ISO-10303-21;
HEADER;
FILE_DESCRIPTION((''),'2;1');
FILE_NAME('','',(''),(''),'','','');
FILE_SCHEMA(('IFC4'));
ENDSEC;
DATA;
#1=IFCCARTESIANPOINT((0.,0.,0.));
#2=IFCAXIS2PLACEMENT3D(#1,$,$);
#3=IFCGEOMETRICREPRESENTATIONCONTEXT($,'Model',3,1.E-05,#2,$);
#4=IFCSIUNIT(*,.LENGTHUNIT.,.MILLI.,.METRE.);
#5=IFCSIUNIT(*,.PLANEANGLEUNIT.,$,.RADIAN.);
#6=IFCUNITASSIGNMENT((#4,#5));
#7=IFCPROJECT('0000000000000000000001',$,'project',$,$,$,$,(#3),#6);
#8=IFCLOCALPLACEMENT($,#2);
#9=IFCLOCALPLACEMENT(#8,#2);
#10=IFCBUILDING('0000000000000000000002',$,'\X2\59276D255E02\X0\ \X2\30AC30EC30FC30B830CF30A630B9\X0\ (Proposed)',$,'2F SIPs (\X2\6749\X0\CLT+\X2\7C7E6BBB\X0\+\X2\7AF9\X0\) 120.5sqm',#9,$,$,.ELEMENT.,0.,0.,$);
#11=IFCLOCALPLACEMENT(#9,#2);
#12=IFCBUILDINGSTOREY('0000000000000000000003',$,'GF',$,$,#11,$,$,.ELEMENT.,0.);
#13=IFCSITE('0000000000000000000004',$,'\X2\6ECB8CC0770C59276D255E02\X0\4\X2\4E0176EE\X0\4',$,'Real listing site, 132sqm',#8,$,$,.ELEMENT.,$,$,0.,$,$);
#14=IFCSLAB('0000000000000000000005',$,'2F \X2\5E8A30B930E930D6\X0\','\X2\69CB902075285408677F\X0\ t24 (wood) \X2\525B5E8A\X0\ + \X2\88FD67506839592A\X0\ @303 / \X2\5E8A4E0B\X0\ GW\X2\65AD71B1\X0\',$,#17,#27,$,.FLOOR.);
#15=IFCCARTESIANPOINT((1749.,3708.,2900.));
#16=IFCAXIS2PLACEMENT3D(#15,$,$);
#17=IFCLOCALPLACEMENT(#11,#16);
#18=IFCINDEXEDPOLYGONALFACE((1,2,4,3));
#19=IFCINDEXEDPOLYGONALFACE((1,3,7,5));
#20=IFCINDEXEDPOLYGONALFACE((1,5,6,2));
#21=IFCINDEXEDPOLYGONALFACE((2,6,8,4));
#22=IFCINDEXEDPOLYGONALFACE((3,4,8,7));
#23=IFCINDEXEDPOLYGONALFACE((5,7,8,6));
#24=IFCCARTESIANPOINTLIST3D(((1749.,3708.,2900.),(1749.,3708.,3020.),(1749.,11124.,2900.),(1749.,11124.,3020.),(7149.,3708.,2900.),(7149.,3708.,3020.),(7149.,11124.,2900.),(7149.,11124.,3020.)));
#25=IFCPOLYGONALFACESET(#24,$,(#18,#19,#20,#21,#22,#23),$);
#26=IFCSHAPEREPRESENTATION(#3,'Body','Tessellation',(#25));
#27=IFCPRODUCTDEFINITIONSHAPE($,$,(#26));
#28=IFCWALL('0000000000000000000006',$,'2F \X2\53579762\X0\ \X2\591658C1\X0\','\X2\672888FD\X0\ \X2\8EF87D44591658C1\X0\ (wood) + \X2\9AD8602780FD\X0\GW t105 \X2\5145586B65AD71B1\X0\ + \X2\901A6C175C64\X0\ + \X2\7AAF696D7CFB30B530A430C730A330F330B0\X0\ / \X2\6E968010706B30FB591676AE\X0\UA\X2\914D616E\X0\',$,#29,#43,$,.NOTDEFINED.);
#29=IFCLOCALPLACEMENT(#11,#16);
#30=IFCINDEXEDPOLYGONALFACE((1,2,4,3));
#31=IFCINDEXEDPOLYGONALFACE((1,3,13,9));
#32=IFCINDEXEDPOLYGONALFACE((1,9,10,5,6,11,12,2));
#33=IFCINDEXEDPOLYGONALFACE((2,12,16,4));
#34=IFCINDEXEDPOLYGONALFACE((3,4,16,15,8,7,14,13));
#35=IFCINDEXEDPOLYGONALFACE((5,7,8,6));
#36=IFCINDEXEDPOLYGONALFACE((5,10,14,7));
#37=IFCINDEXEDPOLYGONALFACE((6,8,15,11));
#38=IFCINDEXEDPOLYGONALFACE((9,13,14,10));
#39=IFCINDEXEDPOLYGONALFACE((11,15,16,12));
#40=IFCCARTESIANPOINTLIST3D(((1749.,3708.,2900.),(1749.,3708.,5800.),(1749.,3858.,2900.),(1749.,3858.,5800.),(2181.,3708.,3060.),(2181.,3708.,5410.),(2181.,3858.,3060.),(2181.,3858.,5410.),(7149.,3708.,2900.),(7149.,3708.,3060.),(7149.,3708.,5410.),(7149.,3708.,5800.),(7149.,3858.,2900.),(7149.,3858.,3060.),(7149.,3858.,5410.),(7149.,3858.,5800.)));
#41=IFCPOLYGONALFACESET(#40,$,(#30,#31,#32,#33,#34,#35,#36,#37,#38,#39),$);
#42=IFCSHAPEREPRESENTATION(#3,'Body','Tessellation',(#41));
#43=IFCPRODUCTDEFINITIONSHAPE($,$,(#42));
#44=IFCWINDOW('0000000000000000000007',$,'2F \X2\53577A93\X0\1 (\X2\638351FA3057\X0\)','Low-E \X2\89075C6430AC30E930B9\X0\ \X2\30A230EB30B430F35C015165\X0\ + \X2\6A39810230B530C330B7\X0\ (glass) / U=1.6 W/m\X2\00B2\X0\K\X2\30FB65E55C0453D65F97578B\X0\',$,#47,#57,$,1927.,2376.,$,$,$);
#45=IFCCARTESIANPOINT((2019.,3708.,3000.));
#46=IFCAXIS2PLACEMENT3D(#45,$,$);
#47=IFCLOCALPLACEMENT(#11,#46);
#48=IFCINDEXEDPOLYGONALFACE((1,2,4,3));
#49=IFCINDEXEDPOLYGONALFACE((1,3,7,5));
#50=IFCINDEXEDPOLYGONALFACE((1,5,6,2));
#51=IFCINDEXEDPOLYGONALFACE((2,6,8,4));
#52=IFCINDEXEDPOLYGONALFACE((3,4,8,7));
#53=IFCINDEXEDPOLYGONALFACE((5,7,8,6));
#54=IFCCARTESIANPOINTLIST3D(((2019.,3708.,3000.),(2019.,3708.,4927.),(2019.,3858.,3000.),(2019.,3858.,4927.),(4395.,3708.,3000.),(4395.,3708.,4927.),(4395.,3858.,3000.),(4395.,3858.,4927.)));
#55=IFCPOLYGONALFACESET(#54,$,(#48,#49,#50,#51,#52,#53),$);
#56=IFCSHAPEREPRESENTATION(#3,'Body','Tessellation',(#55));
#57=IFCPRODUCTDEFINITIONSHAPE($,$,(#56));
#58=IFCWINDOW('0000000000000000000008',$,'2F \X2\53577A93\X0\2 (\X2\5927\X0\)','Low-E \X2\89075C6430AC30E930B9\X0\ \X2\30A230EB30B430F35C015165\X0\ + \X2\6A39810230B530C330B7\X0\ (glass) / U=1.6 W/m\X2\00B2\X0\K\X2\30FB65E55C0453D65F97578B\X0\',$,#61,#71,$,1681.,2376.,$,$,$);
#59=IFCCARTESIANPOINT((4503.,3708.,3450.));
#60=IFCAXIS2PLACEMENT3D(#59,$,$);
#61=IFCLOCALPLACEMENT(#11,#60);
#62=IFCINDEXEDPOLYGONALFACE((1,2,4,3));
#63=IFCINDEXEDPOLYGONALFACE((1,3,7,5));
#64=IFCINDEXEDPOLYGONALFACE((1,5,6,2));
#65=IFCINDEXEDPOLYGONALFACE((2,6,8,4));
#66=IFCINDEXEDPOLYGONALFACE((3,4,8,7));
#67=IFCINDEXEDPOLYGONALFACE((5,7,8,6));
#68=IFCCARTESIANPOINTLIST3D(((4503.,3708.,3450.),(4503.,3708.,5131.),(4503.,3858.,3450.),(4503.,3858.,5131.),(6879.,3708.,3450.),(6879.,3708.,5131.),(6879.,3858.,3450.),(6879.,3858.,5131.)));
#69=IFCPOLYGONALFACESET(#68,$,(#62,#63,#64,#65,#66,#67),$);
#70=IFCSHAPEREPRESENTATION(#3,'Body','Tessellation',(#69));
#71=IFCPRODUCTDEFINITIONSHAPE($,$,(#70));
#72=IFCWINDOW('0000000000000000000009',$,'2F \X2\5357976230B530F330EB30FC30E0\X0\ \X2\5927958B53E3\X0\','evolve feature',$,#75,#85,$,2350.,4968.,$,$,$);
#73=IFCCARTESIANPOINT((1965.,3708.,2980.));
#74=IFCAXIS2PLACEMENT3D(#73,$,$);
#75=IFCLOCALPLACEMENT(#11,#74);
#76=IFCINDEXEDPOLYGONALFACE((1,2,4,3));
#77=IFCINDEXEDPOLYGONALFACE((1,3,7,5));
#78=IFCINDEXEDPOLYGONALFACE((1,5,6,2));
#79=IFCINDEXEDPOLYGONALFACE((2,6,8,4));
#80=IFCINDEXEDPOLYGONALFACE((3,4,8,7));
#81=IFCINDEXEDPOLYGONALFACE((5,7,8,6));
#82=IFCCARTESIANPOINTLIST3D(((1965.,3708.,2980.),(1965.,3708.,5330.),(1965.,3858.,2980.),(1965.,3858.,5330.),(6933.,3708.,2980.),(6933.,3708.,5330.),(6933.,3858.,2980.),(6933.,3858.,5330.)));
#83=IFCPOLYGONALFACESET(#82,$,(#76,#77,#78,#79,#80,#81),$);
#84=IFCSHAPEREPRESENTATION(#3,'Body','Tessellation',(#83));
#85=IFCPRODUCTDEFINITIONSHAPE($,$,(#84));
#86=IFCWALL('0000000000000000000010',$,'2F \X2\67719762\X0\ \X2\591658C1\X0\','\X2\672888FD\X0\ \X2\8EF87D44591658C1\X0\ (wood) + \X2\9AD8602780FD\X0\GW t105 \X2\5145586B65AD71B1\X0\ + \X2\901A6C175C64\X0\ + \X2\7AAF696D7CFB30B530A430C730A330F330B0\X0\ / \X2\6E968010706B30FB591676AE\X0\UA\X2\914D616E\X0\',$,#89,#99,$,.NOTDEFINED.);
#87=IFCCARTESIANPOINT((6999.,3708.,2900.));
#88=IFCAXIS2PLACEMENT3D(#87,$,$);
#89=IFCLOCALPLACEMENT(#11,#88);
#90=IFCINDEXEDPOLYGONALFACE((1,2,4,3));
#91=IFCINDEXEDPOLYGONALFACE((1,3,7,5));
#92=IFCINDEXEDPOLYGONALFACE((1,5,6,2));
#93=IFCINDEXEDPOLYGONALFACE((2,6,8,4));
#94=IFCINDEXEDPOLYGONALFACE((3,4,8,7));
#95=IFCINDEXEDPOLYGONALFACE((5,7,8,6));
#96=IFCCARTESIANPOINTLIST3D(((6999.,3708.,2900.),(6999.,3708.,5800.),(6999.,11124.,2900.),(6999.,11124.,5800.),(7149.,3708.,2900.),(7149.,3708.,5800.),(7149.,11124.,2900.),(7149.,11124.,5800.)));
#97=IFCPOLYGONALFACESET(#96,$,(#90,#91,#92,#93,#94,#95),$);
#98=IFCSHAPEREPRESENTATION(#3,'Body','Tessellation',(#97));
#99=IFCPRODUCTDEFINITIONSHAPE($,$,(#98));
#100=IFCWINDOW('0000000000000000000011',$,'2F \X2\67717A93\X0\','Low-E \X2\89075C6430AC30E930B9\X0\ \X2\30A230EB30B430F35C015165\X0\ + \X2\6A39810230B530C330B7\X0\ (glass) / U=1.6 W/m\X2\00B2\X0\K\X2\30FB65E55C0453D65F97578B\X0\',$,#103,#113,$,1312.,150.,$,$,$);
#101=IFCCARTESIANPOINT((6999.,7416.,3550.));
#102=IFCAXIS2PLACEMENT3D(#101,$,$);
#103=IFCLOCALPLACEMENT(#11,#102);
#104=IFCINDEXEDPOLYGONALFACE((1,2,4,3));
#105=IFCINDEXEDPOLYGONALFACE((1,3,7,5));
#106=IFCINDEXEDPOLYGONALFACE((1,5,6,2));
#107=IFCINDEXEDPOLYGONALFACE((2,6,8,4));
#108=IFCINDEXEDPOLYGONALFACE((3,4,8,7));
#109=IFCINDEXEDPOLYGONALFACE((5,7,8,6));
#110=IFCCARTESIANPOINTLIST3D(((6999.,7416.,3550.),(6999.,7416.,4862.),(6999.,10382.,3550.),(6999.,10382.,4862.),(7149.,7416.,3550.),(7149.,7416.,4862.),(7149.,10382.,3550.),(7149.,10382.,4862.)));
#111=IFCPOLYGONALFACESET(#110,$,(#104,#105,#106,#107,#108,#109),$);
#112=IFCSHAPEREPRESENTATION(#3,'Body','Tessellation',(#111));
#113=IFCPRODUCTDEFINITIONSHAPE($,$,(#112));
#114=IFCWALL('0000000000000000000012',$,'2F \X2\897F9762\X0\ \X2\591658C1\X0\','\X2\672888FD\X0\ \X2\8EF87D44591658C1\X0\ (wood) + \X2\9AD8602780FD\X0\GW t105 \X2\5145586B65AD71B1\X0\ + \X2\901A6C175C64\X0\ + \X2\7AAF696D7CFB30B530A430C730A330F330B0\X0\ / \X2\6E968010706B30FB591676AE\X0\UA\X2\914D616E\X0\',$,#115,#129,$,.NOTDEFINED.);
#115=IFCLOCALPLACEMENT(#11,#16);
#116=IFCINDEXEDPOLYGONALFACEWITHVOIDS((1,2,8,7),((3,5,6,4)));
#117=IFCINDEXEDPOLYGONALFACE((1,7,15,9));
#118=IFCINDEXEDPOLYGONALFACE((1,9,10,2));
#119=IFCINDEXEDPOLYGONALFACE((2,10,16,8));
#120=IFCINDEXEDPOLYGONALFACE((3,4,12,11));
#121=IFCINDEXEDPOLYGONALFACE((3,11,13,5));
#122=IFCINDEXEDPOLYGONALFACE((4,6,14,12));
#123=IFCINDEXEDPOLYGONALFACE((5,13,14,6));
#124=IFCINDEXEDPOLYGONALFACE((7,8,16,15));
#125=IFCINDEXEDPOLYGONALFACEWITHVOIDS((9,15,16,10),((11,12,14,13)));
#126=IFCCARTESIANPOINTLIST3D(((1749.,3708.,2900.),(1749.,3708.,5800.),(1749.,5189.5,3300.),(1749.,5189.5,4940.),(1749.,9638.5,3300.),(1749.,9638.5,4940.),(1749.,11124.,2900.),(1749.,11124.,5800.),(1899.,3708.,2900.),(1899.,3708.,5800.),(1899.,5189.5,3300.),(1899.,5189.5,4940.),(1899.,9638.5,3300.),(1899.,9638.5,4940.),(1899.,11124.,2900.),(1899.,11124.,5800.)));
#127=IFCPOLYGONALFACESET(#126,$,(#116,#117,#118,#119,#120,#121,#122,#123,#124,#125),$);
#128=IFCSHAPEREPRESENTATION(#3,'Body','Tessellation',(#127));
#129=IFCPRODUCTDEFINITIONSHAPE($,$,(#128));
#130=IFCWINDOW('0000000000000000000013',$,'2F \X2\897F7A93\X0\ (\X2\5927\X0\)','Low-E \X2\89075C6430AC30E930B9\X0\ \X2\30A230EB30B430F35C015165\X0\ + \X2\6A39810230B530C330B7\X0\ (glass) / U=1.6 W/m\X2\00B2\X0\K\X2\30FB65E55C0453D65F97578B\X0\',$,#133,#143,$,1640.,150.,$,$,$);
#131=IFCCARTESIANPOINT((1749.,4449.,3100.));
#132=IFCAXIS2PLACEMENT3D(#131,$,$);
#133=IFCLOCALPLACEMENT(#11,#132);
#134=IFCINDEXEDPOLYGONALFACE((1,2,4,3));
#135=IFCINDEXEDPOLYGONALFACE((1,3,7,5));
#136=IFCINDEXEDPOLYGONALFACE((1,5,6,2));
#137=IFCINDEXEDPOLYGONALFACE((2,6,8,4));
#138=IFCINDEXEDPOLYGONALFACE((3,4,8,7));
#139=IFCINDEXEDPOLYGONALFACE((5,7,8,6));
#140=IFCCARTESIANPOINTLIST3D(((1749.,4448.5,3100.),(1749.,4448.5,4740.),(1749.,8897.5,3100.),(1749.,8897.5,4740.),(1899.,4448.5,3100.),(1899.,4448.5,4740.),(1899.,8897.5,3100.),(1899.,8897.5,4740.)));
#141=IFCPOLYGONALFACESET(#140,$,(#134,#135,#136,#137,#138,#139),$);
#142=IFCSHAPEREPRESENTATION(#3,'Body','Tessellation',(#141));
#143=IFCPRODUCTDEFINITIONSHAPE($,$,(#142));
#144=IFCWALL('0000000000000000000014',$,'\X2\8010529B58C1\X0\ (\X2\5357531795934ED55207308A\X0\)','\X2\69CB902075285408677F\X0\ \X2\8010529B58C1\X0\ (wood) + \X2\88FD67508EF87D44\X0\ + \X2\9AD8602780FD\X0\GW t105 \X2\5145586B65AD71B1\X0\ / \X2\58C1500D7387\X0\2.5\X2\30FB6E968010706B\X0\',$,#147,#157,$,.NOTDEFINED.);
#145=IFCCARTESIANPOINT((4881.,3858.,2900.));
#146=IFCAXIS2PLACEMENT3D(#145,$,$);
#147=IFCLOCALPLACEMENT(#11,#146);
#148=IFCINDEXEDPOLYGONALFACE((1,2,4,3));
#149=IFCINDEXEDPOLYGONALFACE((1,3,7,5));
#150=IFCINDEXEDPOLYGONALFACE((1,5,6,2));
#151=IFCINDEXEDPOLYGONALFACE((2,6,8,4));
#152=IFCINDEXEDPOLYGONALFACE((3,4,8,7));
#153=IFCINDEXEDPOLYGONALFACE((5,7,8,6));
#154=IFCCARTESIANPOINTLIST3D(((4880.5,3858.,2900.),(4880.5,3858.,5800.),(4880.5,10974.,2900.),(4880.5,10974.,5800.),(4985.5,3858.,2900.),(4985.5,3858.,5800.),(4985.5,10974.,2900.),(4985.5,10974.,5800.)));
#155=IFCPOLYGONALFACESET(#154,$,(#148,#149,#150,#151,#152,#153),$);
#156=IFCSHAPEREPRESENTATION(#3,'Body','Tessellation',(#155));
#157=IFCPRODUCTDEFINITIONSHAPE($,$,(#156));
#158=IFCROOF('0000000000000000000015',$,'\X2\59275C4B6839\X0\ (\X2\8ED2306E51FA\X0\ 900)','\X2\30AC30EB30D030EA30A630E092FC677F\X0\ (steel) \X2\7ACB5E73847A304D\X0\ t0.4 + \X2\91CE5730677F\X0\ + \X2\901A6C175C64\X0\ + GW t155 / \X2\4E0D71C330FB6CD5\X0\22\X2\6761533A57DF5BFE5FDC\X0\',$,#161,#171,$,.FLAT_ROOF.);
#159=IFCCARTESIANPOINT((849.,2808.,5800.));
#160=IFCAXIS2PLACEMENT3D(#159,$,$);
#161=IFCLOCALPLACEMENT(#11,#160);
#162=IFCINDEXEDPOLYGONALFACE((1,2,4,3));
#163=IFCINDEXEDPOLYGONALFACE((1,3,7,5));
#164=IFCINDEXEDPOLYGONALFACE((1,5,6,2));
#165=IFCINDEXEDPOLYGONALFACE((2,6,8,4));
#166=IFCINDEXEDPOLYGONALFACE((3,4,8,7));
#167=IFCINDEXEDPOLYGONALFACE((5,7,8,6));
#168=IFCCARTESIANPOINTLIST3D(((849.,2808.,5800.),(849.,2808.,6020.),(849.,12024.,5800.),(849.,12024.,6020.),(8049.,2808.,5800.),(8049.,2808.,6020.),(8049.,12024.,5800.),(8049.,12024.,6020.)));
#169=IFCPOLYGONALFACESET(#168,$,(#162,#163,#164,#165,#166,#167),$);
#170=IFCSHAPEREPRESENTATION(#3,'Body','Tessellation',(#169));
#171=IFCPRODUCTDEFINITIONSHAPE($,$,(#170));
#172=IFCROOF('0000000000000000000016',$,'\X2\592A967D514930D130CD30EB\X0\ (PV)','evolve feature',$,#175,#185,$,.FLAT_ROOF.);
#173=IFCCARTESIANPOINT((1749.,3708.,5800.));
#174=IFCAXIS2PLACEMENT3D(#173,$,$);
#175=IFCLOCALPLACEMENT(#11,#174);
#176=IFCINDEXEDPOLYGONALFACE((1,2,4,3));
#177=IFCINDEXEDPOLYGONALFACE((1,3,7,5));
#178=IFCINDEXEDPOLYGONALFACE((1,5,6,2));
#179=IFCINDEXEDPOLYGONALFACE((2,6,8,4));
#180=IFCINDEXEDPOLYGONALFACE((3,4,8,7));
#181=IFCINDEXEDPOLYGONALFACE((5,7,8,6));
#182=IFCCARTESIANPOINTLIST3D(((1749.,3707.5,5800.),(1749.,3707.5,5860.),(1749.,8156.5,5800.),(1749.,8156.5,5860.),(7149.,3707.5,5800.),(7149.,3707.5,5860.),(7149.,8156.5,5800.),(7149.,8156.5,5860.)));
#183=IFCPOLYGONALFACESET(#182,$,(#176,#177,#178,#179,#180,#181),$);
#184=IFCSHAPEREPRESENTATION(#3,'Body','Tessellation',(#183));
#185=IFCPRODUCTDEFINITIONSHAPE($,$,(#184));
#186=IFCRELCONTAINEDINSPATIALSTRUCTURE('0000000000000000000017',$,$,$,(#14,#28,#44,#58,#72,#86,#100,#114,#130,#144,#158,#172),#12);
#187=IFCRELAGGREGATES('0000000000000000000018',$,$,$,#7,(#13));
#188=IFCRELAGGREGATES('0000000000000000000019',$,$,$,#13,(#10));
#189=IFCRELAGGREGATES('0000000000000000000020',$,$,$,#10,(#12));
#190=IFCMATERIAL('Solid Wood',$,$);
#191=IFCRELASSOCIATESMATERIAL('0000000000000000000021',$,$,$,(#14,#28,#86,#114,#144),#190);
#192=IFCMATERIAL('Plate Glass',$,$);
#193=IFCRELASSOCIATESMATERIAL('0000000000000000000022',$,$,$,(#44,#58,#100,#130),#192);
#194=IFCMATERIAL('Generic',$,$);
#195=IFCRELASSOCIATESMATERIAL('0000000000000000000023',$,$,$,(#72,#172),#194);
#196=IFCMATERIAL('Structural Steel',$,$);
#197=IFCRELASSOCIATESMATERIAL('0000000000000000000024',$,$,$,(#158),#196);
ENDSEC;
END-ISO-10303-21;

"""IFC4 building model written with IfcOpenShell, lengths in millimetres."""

from ifc_helpers import new_model, si_unit, frame, frame_2d, origin, place, context, project, spatial, rectangle, extrude, material, element, fill, save


model = new_model("IFC4")

# Units and contexts
model_context = context("Model", 3, precision=1e-05, world=origin())
ifc_project = project(units=[si_unit("LENGTHUNIT", "METRE", prefix="MILLI"), si_unit("PLANEANGLEUNIT", "RADIAN")], contexts=[model_context])

# Site, building, storey
site_placement = place(None, origin())
site = spatial("IfcSite", under=ifc_project, at=site_placement, Name="滋賀県大津市4丁目4", ObjectType="Real listing site, 132sqm", CompositionType="ELEMENT", RefElevation=0.0)
building_placement = place(site_placement, origin())
building = spatial("IfcBuilding", under=site, at=building_placement, Name="大津市 ガレージハウス (Proposed)", ObjectType="2F SIPs (杉CLT+籾殻+竹) 120.5sqm", CompositionType="ELEMENT", ElevationOfRefHeight=0.0, ElevationOfTerrain=0.0)
storey_placement = place(building_placement, origin())
storey = spatial("IfcBuildingStorey", under=building, at=storey_placement, Name="GF", CompositionType="ELEMENT", Elevation=0.0)

# Slab
ifc_material_1 = material(Name="Solid Wood")
slab_placement = place(storey_placement, frame((1749.0, 3708.0, 2900.0)))
element("IfcSlab", 1, at=slab_placement, inside=storey, material=ifc_material_1, Name="2F 床スラブ", Description="構造用合板 t24 (wood) 剛床 + 製材根太 @303 / 床下 GW断熱", PredefinedType="FLOOR", context=model_context, shape_type="SweptSolid", body=[
    extrude(rectangle(XDim=5400.0, YDim=7416.0, at=frame_2d((2700.0, 3708.0))), frame((1749.0, 3708.0, 2900.0)), (0.0, 0.0, 1.0), 120.0),
])

# Wall, openings, windows
wall_1_placement = place(storey_placement, frame((1749.0, 3708.0, 2900.0)))
wall_1 = element("IfcWall", 2, at=wall_1_placement, inside=storey, material=ifc_material_1, Name="2F 南面 外壁", Description="木製 軸組外壁 (wood) + 高性能GW t105 充填断熱 + 通気層 + 窯業系サイディング / 準耐火・外皮UA配慮", PredefinedType="NOTDEFINED", context=model_context, shape_type="SweptSolid", body=[
    extrude(rectangle(XDim=5400.0, YDim=150.0, at=frame_2d((2700.0, 75.0))), frame((1749.0, 3708.0, 2900.0)), (0.0, 0.0, 1.0), 2900.0),
])
opening_1_placement = place(storey_placement, frame((2019.0, 3708.0, 3000.0)))
opening_1 = element("IfcOpeningElement", 3, at=opening_1_placement, cuts=wall_1, PredefinedType="NOTDEFINED", context=model_context, shape_type="SweptSolid", body=[
    extrude(rectangle(XDim=2376.0, YDim=150.0, at=frame_2d((1188.0, 75.0))), frame((2019.0, 3708.0, 3000.0)), (0.0, 0.0, 1.0), 1927.0),
])
opening_2_placement = place(storey_placement, frame((4503.0, 3708.0, 3450.0)))
opening_2 = element("IfcOpeningElement", 4, at=opening_2_placement, cuts=wall_1, PredefinedType="NOTDEFINED", context=model_context, shape_type="SweptSolid", body=[
    extrude(rectangle(XDim=2376.0, YDim=150.0, at=frame_2d((1188.0, 75.0))), frame((4503.0, 3708.0, 3450.0)), (0.0, 0.0, 1.0), 1681.0),
])
opening_3_placement = place(storey_placement, frame((1965.0, 3708.0, 2980.0)))
opening_3 = element("IfcOpeningElement", 5, at=opening_3_placement, cuts=wall_1, PredefinedType="NOTDEFINED", context=model_context, shape_type="SweptSolid", body=[
    extrude(rectangle(XDim=4968.0, YDim=150.0, at=frame_2d((2484.0, 75.0))), frame((1965.0, 3708.0, 2980.0)), (0.0, 0.0, 1.0), 2350.0),
])
ifc_material_2 = material(Name="Plate Glass")
window_1_placement = place(storey_placement, frame((2019.0, 3708.0, 3000.0)))
window_1 = element("IfcWindow", 6, at=window_1_placement, inside=storey, material=ifc_material_2, Name="2F 南窓1 (掃出し)", Description="Low-E 複層ガラス アルゴン封入 + 樹脂サッシ (glass) / U=1.6 W/m²K・日射取得型", OverallHeight=1927.0, OverallWidth=2376.0, context=model_context, shape_type="SweptSolid", body=[
    extrude(rectangle(XDim=2376.0, YDim=150.0, at=frame_2d((1188.0, 75.0))), frame((2019.0, 3708.0, 3000.0)), (0.0, 0.0, 1.0), 1927.0),
])
fill(opening_1, window_1)
window_2_placement = place(storey_placement, frame((4503.0, 3708.0, 3450.0)))
window_2 = element("IfcWindow", 7, at=window_2_placement, inside=storey, material=ifc_material_2, Name="2F 南窓2 (大)", Description="Low-E 複層ガラス アルゴン封入 + 樹脂サッシ (glass) / U=1.6 W/m²K・日射取得型", OverallHeight=1681.0, OverallWidth=2376.0, context=model_context, shape_type="SweptSolid", body=[
    extrude(rectangle(XDim=2376.0, YDim=150.0, at=frame_2d((1188.0, 75.0))), frame((4503.0, 3708.0, 3450.0)), (0.0, 0.0, 1.0), 1681.0),
])
fill(opening_2, window_2)
ifc_material_3 = material(Name="Generic")
window_3_placement = place(storey_placement, frame((1965.0, 3708.0, 2980.0)))
window_3 = element("IfcWindow", 8, at=window_3_placement, inside=storey, material=ifc_material_3, Name="2F 南面サンルーム 大開口", Description="evolve feature", OverallHeight=2350.0, OverallWidth=4968.0, context=model_context, shape_type="SweptSolid", body=[
    extrude(rectangle(XDim=4968.0, YDim=150.0, at=frame_2d((2484.0, 75.0))), frame((1965.0, 3708.0, 2980.0)), (0.0, 0.0, 1.0), 2350.0),
])
fill(opening_3, window_3)

# Walls, openings, windows
wall_2_placement = place(storey_placement, frame((6999.0, 3708.0, 2900.0)))
wall_2 = element("IfcWall", 9, at=wall_2_placement, inside=storey, material=ifc_material_1, Name="2F 東面 外壁", Description="木製 軸組外壁 (wood) + 高性能GW t105 充填断熱 + 通気層 + 窯業系サイディング / 準耐火・外皮UA配慮", PredefinedType="NOTDEFINED", context=model_context, shape_type="SweptSolid", body=[
    extrude(rectangle(XDim=150.0, YDim=7416.0, at=frame_2d((75.0, 3708.0))), frame((6999.0, 3708.0, 2900.0)), (0.0, 0.0, 1.0), 2900.0),
])
opening_4_placement = place(storey_placement, frame((6999.0, 7416.0, 3550.0)))
opening_4 = element("IfcOpeningElement", 10, at=opening_4_placement, cuts=wall_2, PredefinedType="NOTDEFINED", context=model_context, shape_type="SweptSolid", body=[
    extrude(rectangle(XDim=150.0, YDim=2966.0, at=frame_2d((75.0, 1483.0))), frame((6999.0, 7416.0, 3550.0)), (0.0, 0.0, 1.0), 1312.0),
])
window_4_placement = place(storey_placement, frame((6999.0, 7416.0, 3550.0)))
window_4 = element("IfcWindow", 11, at=window_4_placement, inside=storey, material=ifc_material_2, Name="2F 東窓", Description="Low-E 複層ガラス アルゴン封入 + 樹脂サッシ (glass) / U=1.6 W/m²K・日射取得型", OverallHeight=1312.0, OverallWidth=150.0, context=model_context, shape_type="SweptSolid", body=[
    extrude(rectangle(XDim=150.0, YDim=2966.0, at=frame_2d((75.0, 1483.0))), frame((6999.0, 7416.0, 3550.0)), (0.0, 0.0, 1.0), 1312.0),
])
fill(opening_4, window_4)
wall_3_placement = place(storey_placement, frame((1749.0, 3708.0, 2900.0)))
wall_3 = element("IfcWall", 12, at=wall_3_placement, inside=storey, material=ifc_material_1, Name="2F 西面 外壁", Description="木製 軸組外壁 (wood) + 高性能GW t105 充填断熱 + 通気層 + 窯業系サイディング / 準耐火・外皮UA配慮", PredefinedType="NOTDEFINED", context=model_context, shape_type="SweptSolid", body=[
    extrude(rectangle(XDim=150.0, YDim=7416.0, at=frame_2d((75.0, 3708.0))), frame((1749.0, 3708.0, 2900.0)), (0.0, 0.0, 1.0), 2900.0),
])
opening_5_placement = place(storey_placement, frame((1749.0, 4449.0, 3100.0)))
opening_5 = element("IfcOpeningElement", 13, at=opening_5_placement, cuts=wall_3, PredefinedType="NOTDEFINED", context=model_context, shape_type="SweptSolid", body=[
    extrude(rectangle(XDim=150.0, YDim=4449.0, at=frame_2d((75.0, 2224.0))), frame((1749.0, 4449.0, 3100.0)), (0.0, 0.0, 1.0), 1640.0),
])
window_5_placement = place(storey_placement, frame((1749.0, 4449.0, 3100.0)))
window_5 = element("IfcWindow", 14, at=window_5_placement, inside=storey, material=ifc_material_2, Name="2F 西窓 (大)", Description="Low-E 複層ガラス アルゴン封入 + 樹脂サッシ (glass) / U=1.6 W/m²K・日射取得型", OverallHeight=1640.0, OverallWidth=150.0, context=model_context, shape_type="SweptSolid", body=[
    extrude(rectangle(XDim=150.0, YDim=4449.0, at=frame_2d((75.0, 2224.0))), frame((1749.0, 4449.0, 3100.0)), (0.0, 0.0, 1.0), 1640.0),
])
fill(opening_5, window_5)

# Wall
wall_4_placement = place(storey_placement, frame((4881.0, 3858.0, 2900.0)))
element("IfcWall", 15, at=wall_4_placement, inside=storey, material=ifc_material_1, Name="耐力壁 (南北間仕切り)", Description="構造用合板 耐力壁 (wood) + 製材軸組 + 高性能GW t105 充填断熱 / 壁倍率2.5・準耐火", PredefinedType="NOTDEFINED", context=model_context, shape_type="SweptSolid", body=[
    extrude(rectangle(XDim=105.0, YDim=7116.0, at=frame_2d((52.0, 3558.0))), frame((4881.0, 3858.0, 2900.0)), (0.0, 0.0, 1.0), 2900.0),
])

# Roofs
ifc_material_4 = material(Name="Structural Steel")
roof_1_placement = place(storey_placement, frame((849.0, 2808.0, 5800.0)))
element("IfcRoof", 16, at=roof_1_placement, inside=storey, material=ifc_material_4, Name="大屋根 (軒の出 900)", Description="ガルバリウム鋼板 (steel) 立平葺き t0.4 + 野地板 + 通気層 + GW t155 / 不燃・法22条区域対応", PredefinedType="FLAT_ROOF", context=model_context, shape_type="SweptSolid", body=[
    extrude(rectangle(XDim=7200.0, YDim=9216.0, at=frame_2d((3600.0, 4608.0))), frame((849.0, 2808.0, 5800.0)), (0.0, 0.0, 1.0), 220.0),
])
roof_2_placement = place(storey_placement, frame((1749.0, 3708.0, 5800.0)))
element("IfcRoof", 17, at=roof_2_placement, inside=storey, material=ifc_material_3, Name="太陽光パネル (PV)", Description="evolve feature", PredefinedType="FLAT_ROOF", context=model_context, shape_type="SweptSolid", body=[
    extrude(rectangle(XDim=5400.0, YDim=4449.0, at=frame_2d((2700.0, 2224.0))), frame((1749.0, 3708.0, 5800.0)), (0.0, 0.0, 1.0), 60.0),
])

save(model, "model.ifc")
